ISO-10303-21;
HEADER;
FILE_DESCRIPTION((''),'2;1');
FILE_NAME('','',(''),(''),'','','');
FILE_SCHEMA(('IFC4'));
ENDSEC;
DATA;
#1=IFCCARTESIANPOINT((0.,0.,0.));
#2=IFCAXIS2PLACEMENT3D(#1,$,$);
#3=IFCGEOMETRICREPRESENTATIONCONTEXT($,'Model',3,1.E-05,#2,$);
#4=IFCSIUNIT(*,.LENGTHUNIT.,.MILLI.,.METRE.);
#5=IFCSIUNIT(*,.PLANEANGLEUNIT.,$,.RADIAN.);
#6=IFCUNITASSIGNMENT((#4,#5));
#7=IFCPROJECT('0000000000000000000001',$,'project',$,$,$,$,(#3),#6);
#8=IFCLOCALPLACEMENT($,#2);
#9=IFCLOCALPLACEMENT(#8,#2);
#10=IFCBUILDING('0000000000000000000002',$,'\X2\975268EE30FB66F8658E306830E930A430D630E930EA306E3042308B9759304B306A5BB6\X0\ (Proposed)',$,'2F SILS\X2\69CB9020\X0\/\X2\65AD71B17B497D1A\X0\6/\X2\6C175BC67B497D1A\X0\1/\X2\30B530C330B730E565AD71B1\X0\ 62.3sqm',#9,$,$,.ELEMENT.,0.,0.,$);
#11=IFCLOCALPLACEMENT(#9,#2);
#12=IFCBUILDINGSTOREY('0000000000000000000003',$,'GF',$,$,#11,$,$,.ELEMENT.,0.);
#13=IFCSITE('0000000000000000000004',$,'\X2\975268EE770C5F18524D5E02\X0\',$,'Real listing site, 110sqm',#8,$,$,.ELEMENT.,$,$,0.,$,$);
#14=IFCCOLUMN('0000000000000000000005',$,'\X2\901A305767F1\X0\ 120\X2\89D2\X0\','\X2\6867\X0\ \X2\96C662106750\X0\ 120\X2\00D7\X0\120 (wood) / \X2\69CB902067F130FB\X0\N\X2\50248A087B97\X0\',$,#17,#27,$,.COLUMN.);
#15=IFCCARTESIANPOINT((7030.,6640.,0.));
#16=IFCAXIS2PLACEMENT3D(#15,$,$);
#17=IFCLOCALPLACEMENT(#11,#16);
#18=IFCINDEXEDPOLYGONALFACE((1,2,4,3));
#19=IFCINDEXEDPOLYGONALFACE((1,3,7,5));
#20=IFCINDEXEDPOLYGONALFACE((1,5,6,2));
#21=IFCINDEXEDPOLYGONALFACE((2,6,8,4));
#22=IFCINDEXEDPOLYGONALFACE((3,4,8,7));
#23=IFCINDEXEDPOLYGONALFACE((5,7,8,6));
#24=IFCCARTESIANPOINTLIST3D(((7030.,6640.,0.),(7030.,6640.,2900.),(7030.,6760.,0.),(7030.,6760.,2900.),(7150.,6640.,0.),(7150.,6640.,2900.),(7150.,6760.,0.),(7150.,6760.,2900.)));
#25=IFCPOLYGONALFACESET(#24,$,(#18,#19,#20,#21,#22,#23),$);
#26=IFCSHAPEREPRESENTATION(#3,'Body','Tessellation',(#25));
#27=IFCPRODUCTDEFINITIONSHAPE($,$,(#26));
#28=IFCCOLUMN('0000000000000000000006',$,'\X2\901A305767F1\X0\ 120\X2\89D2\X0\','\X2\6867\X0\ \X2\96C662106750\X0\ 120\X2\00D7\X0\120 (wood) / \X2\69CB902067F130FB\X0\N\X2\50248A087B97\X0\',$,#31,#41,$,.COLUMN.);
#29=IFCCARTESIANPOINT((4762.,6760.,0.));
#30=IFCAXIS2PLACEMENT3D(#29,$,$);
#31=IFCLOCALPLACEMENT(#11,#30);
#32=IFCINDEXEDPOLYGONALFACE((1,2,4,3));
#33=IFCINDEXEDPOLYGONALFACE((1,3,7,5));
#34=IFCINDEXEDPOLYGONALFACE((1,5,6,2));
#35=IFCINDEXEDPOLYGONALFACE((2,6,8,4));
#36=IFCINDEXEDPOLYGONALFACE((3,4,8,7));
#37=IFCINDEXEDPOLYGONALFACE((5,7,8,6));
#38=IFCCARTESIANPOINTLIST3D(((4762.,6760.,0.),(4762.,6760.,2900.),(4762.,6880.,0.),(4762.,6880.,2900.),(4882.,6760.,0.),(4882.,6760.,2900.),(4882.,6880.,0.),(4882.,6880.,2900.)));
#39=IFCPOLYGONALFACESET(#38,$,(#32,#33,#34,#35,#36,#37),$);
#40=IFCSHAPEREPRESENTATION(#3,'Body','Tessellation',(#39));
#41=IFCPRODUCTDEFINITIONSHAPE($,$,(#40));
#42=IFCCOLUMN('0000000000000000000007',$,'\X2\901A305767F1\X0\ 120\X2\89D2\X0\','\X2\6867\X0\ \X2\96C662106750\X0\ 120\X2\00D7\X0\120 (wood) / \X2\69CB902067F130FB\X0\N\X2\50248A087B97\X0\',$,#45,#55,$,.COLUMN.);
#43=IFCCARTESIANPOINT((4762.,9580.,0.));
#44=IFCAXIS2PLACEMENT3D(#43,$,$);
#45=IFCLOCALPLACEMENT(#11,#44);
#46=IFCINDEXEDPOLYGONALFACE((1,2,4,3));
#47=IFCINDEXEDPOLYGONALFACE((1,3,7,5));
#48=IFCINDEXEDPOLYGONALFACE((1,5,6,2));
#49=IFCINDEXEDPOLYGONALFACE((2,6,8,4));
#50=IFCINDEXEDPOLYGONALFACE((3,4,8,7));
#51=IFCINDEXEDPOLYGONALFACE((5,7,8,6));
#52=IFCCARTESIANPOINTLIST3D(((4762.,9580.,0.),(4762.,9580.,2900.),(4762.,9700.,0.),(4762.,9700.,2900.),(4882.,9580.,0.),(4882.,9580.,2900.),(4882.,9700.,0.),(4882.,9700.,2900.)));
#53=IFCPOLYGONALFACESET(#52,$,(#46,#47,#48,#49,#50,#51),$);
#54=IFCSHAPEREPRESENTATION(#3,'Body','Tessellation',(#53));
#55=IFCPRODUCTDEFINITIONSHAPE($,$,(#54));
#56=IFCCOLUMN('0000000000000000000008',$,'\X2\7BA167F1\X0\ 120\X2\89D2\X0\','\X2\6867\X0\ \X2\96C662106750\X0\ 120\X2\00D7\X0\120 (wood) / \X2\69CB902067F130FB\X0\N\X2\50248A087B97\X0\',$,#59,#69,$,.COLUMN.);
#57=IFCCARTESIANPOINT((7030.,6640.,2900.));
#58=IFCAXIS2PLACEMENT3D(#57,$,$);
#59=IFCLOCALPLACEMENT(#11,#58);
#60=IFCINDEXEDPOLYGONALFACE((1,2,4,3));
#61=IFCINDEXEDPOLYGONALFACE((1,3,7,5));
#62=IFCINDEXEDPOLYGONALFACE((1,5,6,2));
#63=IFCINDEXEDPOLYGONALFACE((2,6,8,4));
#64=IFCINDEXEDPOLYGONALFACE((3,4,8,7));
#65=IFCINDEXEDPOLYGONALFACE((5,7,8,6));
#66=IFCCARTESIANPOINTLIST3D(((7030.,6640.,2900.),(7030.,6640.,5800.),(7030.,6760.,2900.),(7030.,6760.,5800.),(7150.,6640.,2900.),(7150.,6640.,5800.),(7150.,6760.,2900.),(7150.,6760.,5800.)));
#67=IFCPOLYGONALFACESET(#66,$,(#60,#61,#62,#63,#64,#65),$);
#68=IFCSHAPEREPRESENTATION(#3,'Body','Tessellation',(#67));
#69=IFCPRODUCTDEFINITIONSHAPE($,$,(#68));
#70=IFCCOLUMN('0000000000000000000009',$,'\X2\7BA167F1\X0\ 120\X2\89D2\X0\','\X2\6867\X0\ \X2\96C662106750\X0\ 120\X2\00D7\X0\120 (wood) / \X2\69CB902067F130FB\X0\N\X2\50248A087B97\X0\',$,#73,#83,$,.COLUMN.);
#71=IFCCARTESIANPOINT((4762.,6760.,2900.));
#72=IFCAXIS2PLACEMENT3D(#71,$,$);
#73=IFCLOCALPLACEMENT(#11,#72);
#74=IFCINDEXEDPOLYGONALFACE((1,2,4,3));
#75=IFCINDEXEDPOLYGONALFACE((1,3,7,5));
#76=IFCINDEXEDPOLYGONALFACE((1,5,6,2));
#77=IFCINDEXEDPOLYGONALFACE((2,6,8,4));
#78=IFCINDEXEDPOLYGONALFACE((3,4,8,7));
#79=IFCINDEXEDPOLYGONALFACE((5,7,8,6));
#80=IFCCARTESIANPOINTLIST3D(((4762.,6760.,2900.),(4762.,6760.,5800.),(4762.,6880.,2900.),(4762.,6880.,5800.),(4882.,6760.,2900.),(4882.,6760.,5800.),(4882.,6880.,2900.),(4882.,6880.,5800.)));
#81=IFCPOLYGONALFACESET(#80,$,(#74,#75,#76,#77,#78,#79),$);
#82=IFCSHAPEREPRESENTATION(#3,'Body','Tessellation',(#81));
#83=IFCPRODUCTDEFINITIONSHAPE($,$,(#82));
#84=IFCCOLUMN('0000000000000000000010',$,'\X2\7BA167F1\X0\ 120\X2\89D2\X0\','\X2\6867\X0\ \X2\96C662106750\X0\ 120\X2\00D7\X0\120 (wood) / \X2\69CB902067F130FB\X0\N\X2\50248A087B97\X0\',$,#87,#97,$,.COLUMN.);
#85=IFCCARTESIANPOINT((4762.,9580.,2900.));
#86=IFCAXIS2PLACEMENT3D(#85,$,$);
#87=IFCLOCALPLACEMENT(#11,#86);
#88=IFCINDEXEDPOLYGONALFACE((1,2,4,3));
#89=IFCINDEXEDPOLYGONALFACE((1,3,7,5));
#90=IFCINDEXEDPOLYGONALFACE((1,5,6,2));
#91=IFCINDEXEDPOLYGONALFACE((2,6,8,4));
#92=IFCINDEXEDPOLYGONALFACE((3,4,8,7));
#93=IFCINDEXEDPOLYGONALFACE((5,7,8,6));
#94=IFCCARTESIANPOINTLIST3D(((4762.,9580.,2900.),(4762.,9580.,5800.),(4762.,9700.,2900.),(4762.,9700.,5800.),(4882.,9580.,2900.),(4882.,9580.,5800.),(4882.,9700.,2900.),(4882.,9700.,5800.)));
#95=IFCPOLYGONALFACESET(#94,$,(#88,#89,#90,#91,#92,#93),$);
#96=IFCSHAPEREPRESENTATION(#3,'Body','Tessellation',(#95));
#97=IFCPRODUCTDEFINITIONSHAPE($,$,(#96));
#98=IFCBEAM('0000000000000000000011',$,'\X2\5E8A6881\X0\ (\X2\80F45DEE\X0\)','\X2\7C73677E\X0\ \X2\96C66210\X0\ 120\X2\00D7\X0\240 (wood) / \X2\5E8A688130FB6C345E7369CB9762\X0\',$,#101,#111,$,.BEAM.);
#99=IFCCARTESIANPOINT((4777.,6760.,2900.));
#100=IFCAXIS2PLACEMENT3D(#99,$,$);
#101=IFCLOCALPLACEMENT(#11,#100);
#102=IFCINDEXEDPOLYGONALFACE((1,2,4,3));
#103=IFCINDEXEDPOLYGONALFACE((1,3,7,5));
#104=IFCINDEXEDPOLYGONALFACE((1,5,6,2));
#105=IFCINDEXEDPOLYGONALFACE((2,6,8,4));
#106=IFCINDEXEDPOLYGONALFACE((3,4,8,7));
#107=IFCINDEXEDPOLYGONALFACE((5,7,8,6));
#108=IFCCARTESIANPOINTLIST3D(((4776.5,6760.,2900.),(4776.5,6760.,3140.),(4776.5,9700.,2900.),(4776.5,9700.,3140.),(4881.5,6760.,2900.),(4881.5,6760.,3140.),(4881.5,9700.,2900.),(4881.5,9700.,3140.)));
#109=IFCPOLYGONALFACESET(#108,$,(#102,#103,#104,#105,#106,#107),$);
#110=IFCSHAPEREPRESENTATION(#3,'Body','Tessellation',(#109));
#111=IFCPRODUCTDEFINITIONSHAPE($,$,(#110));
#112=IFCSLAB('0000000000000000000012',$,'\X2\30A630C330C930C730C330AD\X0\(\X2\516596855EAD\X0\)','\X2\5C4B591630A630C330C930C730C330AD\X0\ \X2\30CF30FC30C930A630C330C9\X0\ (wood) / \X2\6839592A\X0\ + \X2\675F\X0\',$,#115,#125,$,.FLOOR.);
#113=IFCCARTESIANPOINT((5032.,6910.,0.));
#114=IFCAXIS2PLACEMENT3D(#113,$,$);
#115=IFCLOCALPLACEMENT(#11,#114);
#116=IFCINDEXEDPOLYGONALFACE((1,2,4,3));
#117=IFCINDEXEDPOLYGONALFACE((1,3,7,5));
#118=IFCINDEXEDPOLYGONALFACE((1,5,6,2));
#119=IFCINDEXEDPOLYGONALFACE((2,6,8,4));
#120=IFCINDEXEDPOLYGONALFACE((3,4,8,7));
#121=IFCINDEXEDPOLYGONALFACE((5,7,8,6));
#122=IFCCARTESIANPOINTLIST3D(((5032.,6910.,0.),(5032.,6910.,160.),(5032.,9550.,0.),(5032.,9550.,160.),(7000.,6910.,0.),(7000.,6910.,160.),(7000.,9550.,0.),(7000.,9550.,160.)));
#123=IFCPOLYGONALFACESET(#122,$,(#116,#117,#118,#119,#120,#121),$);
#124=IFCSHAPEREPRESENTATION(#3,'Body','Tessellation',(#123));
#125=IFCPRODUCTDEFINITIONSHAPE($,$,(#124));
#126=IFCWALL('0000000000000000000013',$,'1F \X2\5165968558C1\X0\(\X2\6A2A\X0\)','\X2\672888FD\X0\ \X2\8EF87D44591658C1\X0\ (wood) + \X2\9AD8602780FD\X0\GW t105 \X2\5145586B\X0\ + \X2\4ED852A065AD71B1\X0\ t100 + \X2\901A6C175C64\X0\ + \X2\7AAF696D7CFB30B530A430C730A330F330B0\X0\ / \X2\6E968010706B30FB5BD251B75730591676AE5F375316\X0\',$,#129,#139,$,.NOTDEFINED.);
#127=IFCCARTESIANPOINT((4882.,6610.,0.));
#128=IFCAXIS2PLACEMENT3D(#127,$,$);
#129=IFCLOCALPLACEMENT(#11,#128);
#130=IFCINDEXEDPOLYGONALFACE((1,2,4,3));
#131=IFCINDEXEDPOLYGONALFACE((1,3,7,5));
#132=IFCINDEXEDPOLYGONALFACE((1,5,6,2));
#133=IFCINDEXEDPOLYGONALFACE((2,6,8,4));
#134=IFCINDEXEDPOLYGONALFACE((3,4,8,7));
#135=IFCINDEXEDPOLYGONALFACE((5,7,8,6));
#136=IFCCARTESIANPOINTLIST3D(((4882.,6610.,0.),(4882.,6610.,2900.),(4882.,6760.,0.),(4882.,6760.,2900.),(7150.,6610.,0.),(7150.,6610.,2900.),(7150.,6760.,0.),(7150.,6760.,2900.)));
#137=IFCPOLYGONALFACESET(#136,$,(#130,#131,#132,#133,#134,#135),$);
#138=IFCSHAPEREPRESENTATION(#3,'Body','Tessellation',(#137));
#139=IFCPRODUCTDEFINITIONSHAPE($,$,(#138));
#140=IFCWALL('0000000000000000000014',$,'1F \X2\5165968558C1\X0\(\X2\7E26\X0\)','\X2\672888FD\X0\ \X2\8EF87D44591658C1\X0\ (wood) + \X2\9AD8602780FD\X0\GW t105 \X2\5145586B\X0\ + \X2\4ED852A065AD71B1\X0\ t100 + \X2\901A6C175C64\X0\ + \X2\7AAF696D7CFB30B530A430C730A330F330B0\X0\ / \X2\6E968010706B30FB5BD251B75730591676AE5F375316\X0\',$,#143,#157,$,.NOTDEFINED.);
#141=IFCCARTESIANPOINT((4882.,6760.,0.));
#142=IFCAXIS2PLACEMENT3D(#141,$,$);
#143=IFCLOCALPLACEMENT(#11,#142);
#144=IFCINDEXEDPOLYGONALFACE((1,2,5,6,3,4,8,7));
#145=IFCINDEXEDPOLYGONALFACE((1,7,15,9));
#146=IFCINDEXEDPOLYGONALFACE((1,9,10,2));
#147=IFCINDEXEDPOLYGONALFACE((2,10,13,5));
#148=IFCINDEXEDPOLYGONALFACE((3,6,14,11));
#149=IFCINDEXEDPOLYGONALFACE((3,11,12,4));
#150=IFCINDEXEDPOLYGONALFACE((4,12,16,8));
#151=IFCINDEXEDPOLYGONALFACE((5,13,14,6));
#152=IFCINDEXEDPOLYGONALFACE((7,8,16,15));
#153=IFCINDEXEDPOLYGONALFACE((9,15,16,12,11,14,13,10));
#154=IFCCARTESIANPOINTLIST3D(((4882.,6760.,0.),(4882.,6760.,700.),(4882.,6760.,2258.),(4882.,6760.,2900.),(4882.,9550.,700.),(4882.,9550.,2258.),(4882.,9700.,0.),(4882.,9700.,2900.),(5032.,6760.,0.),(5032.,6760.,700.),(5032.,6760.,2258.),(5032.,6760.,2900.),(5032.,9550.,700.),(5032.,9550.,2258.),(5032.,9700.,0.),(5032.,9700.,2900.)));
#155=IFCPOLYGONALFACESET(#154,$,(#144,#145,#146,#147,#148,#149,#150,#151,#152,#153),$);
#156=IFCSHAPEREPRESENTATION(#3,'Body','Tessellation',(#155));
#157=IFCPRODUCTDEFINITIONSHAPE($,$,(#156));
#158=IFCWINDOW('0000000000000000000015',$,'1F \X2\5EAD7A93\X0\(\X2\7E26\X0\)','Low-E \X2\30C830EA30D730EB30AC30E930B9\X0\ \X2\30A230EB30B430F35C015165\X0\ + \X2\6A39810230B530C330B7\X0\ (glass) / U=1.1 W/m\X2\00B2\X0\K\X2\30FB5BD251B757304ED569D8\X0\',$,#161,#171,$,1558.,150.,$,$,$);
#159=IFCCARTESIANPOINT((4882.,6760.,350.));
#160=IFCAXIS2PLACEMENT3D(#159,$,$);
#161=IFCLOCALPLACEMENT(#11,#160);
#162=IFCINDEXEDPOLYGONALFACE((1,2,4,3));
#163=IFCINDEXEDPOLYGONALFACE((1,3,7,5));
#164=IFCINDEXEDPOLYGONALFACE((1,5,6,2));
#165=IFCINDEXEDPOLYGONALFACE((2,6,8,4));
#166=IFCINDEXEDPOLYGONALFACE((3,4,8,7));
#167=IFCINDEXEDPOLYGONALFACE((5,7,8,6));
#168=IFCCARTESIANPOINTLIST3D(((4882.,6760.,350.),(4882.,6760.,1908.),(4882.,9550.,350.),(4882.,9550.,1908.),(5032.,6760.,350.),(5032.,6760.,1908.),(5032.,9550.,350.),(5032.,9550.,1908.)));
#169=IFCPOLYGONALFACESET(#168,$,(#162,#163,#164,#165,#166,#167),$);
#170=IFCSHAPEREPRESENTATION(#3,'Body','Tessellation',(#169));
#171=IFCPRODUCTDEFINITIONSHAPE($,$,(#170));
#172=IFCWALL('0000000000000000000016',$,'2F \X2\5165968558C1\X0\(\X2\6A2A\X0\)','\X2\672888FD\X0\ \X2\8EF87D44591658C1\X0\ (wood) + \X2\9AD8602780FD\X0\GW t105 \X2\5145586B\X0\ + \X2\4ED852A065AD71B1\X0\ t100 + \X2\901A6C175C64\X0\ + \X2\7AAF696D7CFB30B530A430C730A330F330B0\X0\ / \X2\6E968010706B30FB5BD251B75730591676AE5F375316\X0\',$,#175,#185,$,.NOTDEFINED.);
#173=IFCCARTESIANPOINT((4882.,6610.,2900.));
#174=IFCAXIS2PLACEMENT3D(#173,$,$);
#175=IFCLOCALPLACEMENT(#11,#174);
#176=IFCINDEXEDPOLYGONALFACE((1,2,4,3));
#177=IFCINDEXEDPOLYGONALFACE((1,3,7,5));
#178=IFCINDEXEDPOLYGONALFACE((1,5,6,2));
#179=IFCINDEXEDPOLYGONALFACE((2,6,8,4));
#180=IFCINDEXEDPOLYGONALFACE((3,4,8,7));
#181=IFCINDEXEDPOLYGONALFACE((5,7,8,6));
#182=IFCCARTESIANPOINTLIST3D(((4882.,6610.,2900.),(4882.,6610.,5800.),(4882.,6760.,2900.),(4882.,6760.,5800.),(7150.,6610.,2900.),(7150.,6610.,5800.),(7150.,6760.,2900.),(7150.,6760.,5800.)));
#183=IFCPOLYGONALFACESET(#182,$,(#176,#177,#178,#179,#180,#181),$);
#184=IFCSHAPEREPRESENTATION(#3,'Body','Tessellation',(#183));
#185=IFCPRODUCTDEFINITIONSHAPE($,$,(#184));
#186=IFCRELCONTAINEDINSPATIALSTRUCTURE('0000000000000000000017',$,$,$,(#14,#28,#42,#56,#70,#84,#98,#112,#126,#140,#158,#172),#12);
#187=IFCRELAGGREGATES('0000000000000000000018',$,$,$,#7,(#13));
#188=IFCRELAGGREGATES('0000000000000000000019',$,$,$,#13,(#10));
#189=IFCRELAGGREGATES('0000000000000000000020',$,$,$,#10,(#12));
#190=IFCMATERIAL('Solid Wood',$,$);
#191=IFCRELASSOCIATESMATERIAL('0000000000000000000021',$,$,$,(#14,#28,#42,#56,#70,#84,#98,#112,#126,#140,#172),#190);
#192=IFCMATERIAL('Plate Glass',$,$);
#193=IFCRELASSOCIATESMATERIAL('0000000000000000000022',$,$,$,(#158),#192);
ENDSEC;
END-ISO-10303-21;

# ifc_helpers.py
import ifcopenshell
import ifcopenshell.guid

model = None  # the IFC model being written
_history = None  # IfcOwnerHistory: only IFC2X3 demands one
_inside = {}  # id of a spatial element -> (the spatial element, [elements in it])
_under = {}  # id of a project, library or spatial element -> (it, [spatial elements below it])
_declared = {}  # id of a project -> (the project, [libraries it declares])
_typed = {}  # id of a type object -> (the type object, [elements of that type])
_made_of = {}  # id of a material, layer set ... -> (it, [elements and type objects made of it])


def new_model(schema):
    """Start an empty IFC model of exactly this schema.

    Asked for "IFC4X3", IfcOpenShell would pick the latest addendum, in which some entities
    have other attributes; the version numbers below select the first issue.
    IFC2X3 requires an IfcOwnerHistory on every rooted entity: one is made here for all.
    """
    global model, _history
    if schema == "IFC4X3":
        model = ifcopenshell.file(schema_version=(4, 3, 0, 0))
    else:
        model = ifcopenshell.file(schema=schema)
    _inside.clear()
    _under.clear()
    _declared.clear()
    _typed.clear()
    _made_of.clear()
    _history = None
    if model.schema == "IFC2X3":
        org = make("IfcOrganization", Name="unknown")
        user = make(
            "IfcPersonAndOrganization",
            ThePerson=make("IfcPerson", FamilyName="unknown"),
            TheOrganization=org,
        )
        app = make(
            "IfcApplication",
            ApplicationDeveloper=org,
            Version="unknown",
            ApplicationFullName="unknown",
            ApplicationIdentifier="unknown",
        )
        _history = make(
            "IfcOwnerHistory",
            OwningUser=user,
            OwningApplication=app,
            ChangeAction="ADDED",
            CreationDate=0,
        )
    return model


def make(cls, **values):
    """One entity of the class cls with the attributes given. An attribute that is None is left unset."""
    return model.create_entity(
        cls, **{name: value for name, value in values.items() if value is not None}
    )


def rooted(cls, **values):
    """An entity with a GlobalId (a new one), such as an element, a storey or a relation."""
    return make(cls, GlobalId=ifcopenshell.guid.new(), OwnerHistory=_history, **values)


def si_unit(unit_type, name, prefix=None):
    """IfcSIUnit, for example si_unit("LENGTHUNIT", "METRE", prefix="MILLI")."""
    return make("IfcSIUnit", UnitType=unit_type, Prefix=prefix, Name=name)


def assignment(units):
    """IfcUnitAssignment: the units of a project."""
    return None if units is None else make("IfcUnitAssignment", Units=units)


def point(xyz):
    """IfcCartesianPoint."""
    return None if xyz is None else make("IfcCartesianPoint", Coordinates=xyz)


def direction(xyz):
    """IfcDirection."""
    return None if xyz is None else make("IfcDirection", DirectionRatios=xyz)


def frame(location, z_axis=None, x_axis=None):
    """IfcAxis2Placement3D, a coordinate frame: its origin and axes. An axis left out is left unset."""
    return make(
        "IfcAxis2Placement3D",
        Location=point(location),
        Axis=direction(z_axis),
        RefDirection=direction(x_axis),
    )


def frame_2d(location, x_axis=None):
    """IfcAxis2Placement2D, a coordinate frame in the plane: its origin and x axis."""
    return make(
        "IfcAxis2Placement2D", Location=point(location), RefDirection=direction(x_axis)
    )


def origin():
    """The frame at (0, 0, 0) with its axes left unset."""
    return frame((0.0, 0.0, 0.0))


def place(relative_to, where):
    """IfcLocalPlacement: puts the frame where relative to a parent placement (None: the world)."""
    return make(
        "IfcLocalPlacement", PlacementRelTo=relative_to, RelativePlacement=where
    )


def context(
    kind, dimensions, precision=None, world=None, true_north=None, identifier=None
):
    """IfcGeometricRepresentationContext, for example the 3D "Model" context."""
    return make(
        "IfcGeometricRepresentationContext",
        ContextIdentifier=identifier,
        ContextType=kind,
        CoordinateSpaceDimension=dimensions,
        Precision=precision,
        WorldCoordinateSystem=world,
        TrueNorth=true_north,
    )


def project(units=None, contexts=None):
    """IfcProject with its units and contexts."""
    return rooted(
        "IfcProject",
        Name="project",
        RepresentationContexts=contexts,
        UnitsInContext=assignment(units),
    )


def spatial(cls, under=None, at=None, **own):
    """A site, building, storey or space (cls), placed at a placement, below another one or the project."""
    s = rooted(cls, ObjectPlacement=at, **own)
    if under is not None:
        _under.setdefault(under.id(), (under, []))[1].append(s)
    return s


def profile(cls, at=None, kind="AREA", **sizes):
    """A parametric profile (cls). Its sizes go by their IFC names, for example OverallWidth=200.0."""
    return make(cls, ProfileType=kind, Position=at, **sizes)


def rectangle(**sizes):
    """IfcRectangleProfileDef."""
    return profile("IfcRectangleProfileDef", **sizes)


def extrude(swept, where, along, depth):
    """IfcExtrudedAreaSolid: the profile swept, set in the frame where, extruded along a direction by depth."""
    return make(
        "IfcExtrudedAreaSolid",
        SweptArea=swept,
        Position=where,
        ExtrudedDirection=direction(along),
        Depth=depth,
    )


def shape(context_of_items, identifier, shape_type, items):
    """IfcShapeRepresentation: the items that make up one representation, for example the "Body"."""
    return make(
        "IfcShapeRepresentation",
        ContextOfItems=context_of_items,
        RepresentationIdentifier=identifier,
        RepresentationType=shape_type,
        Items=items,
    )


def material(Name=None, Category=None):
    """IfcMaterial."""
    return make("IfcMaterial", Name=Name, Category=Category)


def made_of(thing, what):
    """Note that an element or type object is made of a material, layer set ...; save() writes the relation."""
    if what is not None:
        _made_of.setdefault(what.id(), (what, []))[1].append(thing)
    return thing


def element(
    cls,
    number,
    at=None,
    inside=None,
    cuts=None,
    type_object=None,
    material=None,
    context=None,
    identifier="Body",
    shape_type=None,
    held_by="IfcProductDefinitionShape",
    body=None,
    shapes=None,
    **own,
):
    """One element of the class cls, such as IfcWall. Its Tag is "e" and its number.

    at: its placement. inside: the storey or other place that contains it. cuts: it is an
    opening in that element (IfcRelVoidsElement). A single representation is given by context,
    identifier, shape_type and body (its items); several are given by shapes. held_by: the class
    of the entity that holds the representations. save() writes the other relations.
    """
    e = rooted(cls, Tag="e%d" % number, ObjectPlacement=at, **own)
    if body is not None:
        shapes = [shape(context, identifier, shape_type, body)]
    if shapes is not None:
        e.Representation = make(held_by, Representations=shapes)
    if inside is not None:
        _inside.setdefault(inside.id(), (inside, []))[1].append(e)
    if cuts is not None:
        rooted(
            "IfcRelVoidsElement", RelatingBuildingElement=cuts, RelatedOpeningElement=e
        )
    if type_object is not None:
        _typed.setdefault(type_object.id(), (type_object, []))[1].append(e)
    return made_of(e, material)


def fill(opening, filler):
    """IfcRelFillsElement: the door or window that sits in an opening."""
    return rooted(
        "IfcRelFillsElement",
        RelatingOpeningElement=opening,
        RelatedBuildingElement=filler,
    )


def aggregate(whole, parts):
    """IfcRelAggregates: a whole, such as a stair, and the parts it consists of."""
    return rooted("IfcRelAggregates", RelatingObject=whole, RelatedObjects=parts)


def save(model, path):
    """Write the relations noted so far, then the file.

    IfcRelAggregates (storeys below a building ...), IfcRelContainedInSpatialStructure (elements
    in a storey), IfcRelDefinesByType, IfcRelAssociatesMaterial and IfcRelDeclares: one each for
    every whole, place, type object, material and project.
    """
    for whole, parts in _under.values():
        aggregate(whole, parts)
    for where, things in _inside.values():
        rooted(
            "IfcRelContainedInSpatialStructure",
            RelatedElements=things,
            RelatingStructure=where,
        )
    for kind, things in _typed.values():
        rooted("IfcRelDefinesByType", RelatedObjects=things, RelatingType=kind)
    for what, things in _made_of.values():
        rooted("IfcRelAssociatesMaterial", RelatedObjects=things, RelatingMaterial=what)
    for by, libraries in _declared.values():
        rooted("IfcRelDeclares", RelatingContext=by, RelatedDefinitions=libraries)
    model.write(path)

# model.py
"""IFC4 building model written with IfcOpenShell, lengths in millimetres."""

from ifc_helpers import new_model, si_unit, frame, frame_2d, origin, place, context, project, spatial, rectangle, extrude, material, element, fill, save


model = new_model("IFC4")

# Units and contexts
model_context = context("Model", 3, precision=1e-05, world=origin())
ifc_project = project(units=[si_unit("LENGTHUNIT", "METRE", prefix="MILLI"), si_unit("PLANEANGLEUNIT", "RADIAN")], contexts=[model_context])

# Site, building, storey
site_placement = place(None, origin())
site = spatial("IfcSite", under=ifc_project, at=site_placement, Name="青森県弘前市", ObjectType="Real listing site, 110sqm", CompositionType="ELEMENT", RefElevation=0.0)
building_placement = place(site_placement, origin())
building = spatial("IfcBuilding", under=site, at=building_placement, Name="青森・書斎とライブラリのある静かな家 (Proposed)", ObjectType="2F SILS構造/断熱等級6/気密等級1/サッシュ断熱 62.3sqm", CompositionType="ELEMENT", ElevationOfRefHeight=0.0, ElevationOfTerrain=0.0)
storey_placement = place(building_placement, origin())
storey = spatial("IfcBuildingStorey", under=building, at=storey_placement, Name="GF", CompositionType="ELEMENT", Elevation=0.0)

# Columns
ifc_material_1 = material(Name="Solid Wood")
column_1_placement = place(storey_placement, frame((7030.0, 6640.0, 0.0)))
element("IfcColumn", 1, at=column_1_placement, inside=storey, material=ifc_material_1, Name="通し柱 120角", Description="桧 集成材 120×120 (wood) / 構造柱・N値計算", PredefinedType="COLUMN", context=model_context, shape_type="SweptSolid", body=[
    extrude(rectangle(XDim=120.0, YDim=120.0, at=frame_2d((60.0, 60.0))), frame((7030.0, 6640.0, 0.0)), (0.0, 0.0, 1.0), 2900.0),
])
column_2_placement = place(storey_placement, frame((4762.0, 6760.0, 0.0)))
element("IfcColumn", 2, at=column_2_placement, inside=storey, material=ifc_material_1, Name="通し柱 120角", Description="桧 集成材 120×120 (wood) / 構造柱・N値計算", PredefinedType="COLUMN", context=model_context, shape_type="SweptSolid", body=[
    extrude(rectangle(XDim=120.0, YDim=120.0, at=frame_2d((60.0, 60.0))), frame((4762.0, 6760.0, 0.0)), (0.0, 0.0, 1.0), 2900.0),
])
column_3_placement = place(storey_placement, frame((4762.0, 9580.0, 0.0)))
element("IfcColumn", 3, at=column_3_placement, inside=storey, material=ifc_material_1, Name="通し柱 120角", Description="桧 集成材 120×120 (wood) / 構造柱・N値計算", PredefinedType="COLUMN", context=model_context, shape_type="SweptSolid", body=[
    extrude(rectangle(XDim=120.0, YDim=120.0, at=frame_2d((60.0, 60.0))), frame((4762.0, 9580.0, 0.0)), (0.0, 0.0, 1.0), 2900.0),
])
column_4_placement = place(storey_placement, frame((7030.0, 6640.0, 2900.0)))
element("IfcColumn", 4, at=column_4_placement, inside=storey, material=ifc_material_1, Name="管柱 120角", Description="桧 集成材 120×120 (wood) / 構造柱・N値計算", PredefinedType="COLUMN", context=model_context, shape_type="SweptSolid", body=[
    extrude(rectangle(XDim=120.0, YDim=120.0, at=frame_2d((60.0, 60.0))), frame((7030.0, 6640.0, 2900.0)), (0.0, 0.0, 1.0), 2900.0),
])
column_5_placement = place(storey_placement, frame((4762.0, 6760.0, 2900.0)))
element("IfcColumn", 5, at=column_5_placement, inside=storey, material=ifc_material_1, Name="管柱 120角", Description="桧 集成材 120×120 (wood) / 構造柱・N値計算", PredefinedType="COLUMN", context=model_context, shape_type="SweptSolid", body=[
    extrude(rectangle(XDim=120.0, YDim=120.0, at=frame_2d((60.0, 60.0))), frame((4762.0, 6760.0, 2900.0)), (0.0, 0.0, 1.0), 2900.0),
])
column_6_placement = place(storey_placement, frame((4762.0, 9580.0, 2900.0)))
element("IfcColumn", 6, at=column_6_placement, inside=storey, material=ifc_material_1, Name="管柱 120角", Description="桧 集成材 120×120 (wood) / 構造柱・N値計算", PredefinedType="COLUMN", context=model_context, shape_type="SweptSolid", body=[
    extrude(rectangle(XDim=120.0, YDim=120.0, at=frame_2d((60.0, 60.0))), frame((4762.0, 9580.0, 2900.0)), (0.0, 0.0, 1.0), 2900.0),
])

# Beam
beam_1_placement = place(storey_placement, frame((4777.0, 6760.0, 2900.0)))
element("IfcBeam", 7, at=beam_1_placement, inside=storey, material=ifc_material_1, Name="床梁 (胴差)", Description="米松 集成 120×240 (wood) / 床梁・水平構面", PredefinedType="BEAM", context=model_context, shape_type="SweptSolid", body=[
    extrude(rectangle(XDim=105.0, YDim=2940.0, at=frame_2d((52.0, 1470.0))), frame((4777.0, 6760.0, 2900.0)), (0.0, 0.0, 1.0), 240.0),
])

# Slab
slab_placement = place(storey_placement, frame((5032.0, 6910.0, 0.0)))
element("IfcSlab", 8, at=slab_placement, inside=storey, material=ifc_material_1, Name="ウッドデッキ(入隅庭)", Description="屋外ウッドデッキ ハードウッド (wood) / 根太 + 束", PredefinedType="FLOOR", context=model_context, shape_type="SweptSolid", body=[
    extrude(rectangle(XDim=1968.0, YDim=2640.0, at=frame_2d((984.0, 1320.0))), frame((5032.0, 6910.0, 0.0)), (0.0, 0.0, 1.0), 160.0),
])

# Wall
wall_1_placement = place(storey_placement, frame((4882.0, 6610.0, 0.0)))
element("IfcWall", 9, at=wall_1_placement, inside=storey, material=ifc_material_1, Name="1F 入隅壁(横)", Description="木製 軸組外壁 (wood) + 高性能GW t105 充填 + 付加断熱 t100 + 通気層 + 窯業系サイディング / 準耐火・寒冷地外皮強化", PredefinedType="NOTDEFINED", context=model_context, shape_type="SweptSolid", body=[
    extrude(rectangle(XDim=2268.0, YDim=150.0, at=frame_2d((1134.0, 75.0))), frame((4882.0, 6610.0, 0.0)), (0.0, 0.0, 1.0), 2900.0),
])

# Wall, opening, window
wall_2_placement = place(storey_placement, frame((4882.0, 6760.0, 0.0)))
wall_2 = element("IfcWall", 10, at=wall_2_placement, inside=storey, material=ifc_material_1, Name="1F 入隅壁(縦)", Description="木製 軸組外壁 (wood) + 高性能GW t105 充填 + 付加断熱 t100 + 通気層 + 窯業系サイディング / 準耐火・寒冷地外皮強化", PredefinedType="NOTDEFINED", context=model_context, shape_type="SweptSolid", body=[
    extrude(rectangle(XDim=150.0, YDim=2940.0, at=frame_2d((75.0, 1470.0))), frame((4882.0, 6760.0, 0.0)), (0.0, 0.0, 1.0), 2900.0),
])
opening_1_placement = place(storey_placement, frame((4882.0, 6760.0, 350.0)))
opening_1 = element("IfcOpeningElement", 11, at=opening_1_placement, cuts=wall_2, PredefinedType="NOTDEFINED", context=model_context, shape_type="SweptSolid", body=[
    extrude(rectangle(XDim=150.0, YDim=2790.0, at=frame_2d((75.0, 1395.0))), frame((4882.0, 6760.0, 350.0)), (0.0, 0.0, 1.0), 1558.0),
])
ifc_material_2 = material(Name="Plate Glass")
window_1_placement = place(storey_placement, frame((4882.0, 6760.0, 350.0)))
window_1 = element("IfcWindow", 12, at=window_1_placement, inside=storey, material=ifc_material_2, Name="1F 庭窓(縦)", Description="Low-E トリプルガラス アルゴン封入 + 樹脂サッシ (glass) / U=1.1 W/m²K・寒冷地仕様", OverallHeight=1558.0, OverallWidth=150.0, context=model_context, shape_type="SweptSolid", body=[
    extrude(rectangle(XDim=150.0, YDim=2790.0, at=frame_2d((75.0, 1395.0))), frame((4882.0, 6760.0, 350.0)), (0.0, 0.0, 1.0), 1558.0),
])
fill(opening_1, window_1)

# Wall
wall_3_placement = place(storey_placement, frame((4882.0, 6610.0, 2900.0)))
element("IfcWall", 13, at=wall_3_placement, inside=storey, material=ifc_material_1, Name="2F 入隅壁(横)", Description="木製 軸組外壁 (wood) + 高性能GW t105 充填 + 付加断熱 t100 + 通気層 + 窯業系サイディング / 準耐火・寒冷地外皮強化", PredefinedType="NOTDEFINED", context=model_context, shape_type="SweptSolid", body=[
    extrude(rectangle(XDim=2268.0, YDim=150.0, at=frame_2d((1134.0, 75.0))), frame((4882.0, 6610.0, 2900.0)), (0.0, 0.0, 1.0), 2900.0),
])

save(model, "model.ifc")
